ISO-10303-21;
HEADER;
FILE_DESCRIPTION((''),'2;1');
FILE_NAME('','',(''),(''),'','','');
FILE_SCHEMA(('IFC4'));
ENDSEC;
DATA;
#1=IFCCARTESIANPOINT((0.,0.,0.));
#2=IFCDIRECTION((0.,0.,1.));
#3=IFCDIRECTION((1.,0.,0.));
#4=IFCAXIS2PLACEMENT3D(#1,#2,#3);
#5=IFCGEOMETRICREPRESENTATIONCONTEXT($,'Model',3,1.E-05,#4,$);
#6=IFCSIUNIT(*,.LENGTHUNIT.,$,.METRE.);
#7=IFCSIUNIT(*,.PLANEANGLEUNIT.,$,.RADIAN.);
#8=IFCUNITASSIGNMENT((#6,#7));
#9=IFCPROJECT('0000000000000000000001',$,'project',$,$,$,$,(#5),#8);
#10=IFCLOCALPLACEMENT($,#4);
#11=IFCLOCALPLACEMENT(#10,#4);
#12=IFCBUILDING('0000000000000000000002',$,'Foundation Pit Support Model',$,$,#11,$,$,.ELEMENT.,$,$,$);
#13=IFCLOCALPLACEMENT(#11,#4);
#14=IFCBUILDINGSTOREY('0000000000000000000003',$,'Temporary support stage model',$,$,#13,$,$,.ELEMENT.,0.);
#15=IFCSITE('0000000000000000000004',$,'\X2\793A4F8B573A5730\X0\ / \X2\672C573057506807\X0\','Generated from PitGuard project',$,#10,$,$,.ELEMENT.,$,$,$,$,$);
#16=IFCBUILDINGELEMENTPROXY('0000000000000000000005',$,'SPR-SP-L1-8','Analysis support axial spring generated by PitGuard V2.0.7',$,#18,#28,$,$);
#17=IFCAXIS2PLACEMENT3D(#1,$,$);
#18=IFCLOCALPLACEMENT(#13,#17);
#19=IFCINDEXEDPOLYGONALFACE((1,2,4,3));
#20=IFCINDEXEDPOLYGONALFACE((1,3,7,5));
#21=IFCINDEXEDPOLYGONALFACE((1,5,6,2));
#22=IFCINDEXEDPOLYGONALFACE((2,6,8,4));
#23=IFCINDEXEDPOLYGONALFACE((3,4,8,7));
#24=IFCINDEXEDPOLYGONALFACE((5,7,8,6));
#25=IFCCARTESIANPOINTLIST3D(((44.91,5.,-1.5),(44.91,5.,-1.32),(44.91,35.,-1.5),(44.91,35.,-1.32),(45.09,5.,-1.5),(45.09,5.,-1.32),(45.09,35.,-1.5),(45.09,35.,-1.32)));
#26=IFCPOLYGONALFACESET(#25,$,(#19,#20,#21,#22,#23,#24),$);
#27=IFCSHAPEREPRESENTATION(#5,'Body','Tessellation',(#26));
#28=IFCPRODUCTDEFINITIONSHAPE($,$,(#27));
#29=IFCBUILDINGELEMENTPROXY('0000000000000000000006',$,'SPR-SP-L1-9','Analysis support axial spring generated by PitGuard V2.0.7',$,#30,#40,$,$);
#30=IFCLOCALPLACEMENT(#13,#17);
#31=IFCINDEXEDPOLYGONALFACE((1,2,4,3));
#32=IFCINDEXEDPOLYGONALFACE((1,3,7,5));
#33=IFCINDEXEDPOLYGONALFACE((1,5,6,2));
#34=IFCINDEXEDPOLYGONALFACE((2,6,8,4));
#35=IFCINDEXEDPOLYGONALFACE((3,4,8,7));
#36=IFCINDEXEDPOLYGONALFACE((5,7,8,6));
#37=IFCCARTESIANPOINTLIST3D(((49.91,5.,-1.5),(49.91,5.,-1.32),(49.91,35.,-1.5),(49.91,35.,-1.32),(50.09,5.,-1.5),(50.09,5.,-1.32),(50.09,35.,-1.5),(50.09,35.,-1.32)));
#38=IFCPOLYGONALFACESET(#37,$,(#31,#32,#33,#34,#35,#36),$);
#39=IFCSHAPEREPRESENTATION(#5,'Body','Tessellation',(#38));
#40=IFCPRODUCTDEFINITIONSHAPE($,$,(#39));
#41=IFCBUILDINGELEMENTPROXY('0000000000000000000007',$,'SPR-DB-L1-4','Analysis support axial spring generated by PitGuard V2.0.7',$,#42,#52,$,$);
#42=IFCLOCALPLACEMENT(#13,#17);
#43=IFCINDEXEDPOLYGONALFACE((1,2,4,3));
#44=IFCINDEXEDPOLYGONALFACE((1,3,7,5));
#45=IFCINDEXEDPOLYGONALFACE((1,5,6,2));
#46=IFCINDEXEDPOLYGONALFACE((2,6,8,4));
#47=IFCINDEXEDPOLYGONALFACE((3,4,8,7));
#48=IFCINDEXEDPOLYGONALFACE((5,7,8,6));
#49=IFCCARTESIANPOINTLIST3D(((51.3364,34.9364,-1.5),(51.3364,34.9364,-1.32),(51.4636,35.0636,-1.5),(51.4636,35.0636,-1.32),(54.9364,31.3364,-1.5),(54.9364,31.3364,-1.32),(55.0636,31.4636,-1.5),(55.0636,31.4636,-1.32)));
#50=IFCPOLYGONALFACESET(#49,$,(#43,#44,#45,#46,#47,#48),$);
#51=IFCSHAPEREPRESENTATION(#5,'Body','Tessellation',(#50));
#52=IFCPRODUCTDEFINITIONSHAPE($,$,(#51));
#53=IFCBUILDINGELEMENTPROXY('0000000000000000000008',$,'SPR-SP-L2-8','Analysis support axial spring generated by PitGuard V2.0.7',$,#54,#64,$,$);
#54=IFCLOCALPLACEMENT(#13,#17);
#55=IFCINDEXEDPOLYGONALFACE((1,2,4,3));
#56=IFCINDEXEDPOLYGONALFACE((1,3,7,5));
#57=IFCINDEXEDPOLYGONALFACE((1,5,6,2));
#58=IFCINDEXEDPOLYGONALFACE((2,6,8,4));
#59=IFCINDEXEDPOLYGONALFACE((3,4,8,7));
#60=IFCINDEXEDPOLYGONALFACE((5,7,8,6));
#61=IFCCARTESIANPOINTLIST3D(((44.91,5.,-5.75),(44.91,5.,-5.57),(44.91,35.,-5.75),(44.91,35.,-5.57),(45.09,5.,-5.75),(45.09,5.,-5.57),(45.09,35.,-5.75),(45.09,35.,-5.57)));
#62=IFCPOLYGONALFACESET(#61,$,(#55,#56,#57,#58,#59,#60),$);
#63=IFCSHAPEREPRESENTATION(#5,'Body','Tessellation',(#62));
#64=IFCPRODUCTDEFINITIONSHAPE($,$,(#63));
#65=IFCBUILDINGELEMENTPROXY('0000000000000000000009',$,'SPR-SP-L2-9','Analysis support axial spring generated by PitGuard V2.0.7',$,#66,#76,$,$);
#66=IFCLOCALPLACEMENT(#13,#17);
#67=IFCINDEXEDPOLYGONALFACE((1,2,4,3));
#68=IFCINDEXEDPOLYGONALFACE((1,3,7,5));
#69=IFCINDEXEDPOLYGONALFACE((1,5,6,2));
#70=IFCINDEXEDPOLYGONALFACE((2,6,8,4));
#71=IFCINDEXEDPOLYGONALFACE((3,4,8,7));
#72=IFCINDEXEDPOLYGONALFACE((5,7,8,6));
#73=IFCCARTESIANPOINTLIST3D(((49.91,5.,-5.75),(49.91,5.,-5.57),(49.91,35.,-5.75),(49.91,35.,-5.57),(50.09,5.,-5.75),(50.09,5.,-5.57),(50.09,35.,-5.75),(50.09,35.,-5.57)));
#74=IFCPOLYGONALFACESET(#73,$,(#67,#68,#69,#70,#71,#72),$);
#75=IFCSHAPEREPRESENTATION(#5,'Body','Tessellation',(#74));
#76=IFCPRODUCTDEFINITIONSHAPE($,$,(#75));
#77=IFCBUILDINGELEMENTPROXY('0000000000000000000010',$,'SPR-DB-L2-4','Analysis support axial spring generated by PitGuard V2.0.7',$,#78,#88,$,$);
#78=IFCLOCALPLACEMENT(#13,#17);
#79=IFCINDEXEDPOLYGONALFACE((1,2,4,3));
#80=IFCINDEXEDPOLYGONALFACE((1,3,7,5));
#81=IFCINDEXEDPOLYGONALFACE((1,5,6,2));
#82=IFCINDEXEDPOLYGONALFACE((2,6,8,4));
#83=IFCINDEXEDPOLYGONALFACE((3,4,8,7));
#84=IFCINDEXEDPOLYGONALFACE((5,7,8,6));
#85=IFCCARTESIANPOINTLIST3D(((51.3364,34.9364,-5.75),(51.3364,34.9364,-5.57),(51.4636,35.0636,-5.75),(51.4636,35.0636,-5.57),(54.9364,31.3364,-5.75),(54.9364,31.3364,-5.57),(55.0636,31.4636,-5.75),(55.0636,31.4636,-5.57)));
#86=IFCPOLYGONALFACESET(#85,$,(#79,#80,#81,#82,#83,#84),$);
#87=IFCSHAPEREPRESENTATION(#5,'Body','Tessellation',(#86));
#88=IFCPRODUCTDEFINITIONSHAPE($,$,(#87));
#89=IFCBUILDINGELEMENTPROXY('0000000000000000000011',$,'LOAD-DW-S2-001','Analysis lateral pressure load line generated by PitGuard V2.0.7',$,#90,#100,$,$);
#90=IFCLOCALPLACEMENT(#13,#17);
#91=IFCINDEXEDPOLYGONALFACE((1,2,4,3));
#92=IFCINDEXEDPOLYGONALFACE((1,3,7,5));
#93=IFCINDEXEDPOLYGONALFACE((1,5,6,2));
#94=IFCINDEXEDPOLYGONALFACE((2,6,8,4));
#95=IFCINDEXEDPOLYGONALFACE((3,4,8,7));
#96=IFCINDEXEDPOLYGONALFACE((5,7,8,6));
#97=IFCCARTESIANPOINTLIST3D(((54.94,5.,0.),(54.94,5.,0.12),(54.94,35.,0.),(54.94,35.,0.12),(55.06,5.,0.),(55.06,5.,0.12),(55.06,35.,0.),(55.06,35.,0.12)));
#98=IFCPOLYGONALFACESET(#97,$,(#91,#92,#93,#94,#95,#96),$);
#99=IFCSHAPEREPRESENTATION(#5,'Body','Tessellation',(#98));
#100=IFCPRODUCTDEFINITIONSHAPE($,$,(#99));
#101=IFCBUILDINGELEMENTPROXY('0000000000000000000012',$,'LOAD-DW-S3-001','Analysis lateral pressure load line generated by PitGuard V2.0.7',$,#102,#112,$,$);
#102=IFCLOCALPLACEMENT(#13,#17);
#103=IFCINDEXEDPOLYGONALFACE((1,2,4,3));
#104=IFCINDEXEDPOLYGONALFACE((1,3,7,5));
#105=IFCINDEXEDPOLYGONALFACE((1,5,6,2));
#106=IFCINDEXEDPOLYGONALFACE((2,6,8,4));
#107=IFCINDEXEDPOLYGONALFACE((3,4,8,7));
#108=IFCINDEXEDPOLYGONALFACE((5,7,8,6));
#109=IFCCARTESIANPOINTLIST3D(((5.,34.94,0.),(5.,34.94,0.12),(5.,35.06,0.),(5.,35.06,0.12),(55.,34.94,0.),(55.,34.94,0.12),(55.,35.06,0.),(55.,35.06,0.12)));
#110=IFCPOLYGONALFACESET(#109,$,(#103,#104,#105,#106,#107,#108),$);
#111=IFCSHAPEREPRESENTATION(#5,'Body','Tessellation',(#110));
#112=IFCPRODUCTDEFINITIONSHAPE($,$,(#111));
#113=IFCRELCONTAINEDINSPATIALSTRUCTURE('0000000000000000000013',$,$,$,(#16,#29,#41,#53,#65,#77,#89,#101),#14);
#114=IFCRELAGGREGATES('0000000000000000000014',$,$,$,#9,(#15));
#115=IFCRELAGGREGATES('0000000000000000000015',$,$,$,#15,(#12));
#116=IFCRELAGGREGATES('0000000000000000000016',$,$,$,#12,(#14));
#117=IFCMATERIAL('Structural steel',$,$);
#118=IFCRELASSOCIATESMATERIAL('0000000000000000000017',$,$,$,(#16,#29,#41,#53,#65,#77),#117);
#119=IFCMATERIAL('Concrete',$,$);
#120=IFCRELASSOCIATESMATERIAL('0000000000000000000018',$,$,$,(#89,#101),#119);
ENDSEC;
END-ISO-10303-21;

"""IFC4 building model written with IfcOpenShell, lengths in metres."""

from ifc_helpers import new_model, si_unit, frame, origin_with_axes, origin_2d, place, context, project, spatial, rectangle, extrude, material, element, save


model = new_model("IFC4")

# Units and contexts
model_context = context("Model", 3, precision=1e-05, world=origin_with_axes())
ifc_project = project(units=[si_unit("LENGTHUNIT", "METRE"), si_unit("PLANEANGLEUNIT", "RADIAN")], contexts=[model_context])

# Site, building, storey
site_placement = place(None, origin_with_axes())
site = spatial("IfcSite", under=ifc_project, at=site_placement, Name="示例场地 / 本地坐标", Description="Generated from PitGuard project", CompositionType="ELEMENT")
building_placement = place(site_placement, origin_with_axes())
building = spatial("IfcBuilding", under=site, at=building_placement, Name="Foundation Pit Support Model", CompositionType="ELEMENT")
storey_placement = place(building_placement, origin_with_axes())
storey = spatial("IfcBuildingStorey", under=building, at=storey_placement, Name="Temporary support stage model", CompositionType="ELEMENT", Elevation=0.0)

# Shared definitions
ifc_material_1 = material(Name="Concrete")

# Building element proxies
ifc_material_2 = material(Name="Structural steel")
for number, where, z_axis, x_axis, name in (
    (1, (45.0, 20.0, -1.5), (0.0, 0.0, 1.0), (0.0, 1.0, 0.0), "SPR-SP-L1-8"),
    (2, (50.0, 20.0, -1.5), (0.0, 0.0, 1.0), (0.0, 1.0, 0.0), "SPR-SP-L1-9"),
):
    element("IfcBuildingElementProxy", number, at=place(storey_placement, frame(where, z_axis=z_axis, x_axis=x_axis)), inside=storey, material=ifc_material_2, Name=name, Description="Analysis support axial spring generated by PitGuard V2.0.7", context=model_context, shape_type="SweptSolid", body=[
        extrude(rectangle(XDim=30.0, YDim=0.18, at=origin_2d()), origin_with_axes(), (0.0, 0.0, 1.0), 0.18),
    ])
proxy_1_placement = place(storey_placement, frame((53.2, 33.2, -1.5), z_axis=(0.0, 0.0, 1.0), x_axis=(-0.707107, 0.707107, 0.0)))
element("IfcBuildingElementProxy", 3, at=proxy_1_placement, inside=storey, material=ifc_material_2, Name="SPR-DB-L1-4", Description="Analysis support axial spring generated by PitGuard V2.0.7", context=model_context, shape_type="SweptSolid", body=[
    extrude(rectangle(XDim=5.0912, YDim=0.18, at=origin_2d()), origin_with_axes(), (0.0, 0.0, 1.0), 0.18),
])
for number, where, z_axis, x_axis, name in (
    (4, (45.0, 20.0, -5.75), (0.0, 0.0, 1.0), (0.0, 1.0, 0.0), "SPR-SP-L2-8"),
    (5, (50.0, 20.0, -5.75), (0.0, 0.0, 1.0), (0.0, 1.0, 0.0), "SPR-SP-L2-9"),
):
    element("IfcBuildingElementProxy", number, at=place(storey_placement, frame(where, z_axis=z_axis, x_axis=x_axis)), inside=storey, material=ifc_material_2, Name=name, Description="Analysis support axial spring generated by PitGuard V2.0.7", context=model_context, shape_type="SweptSolid", body=[
        extrude(rectangle(XDim=30.0, YDim=0.18, at=origin_2d()), origin_with_axes(), (0.0, 0.0, 1.0), 0.18),
    ])
proxy_2_placement = place(storey_placement, frame((53.2, 33.2, -5.75), z_axis=(0.0, 0.0, 1.0), x_axis=(-0.707107, 0.707107, 0.0)))
element("IfcBuildingElementProxy", 6, at=proxy_2_placement, inside=storey, material=ifc_material_2, Name="SPR-DB-L2-4", Description="Analysis support axial spring generated by PitGuard V2.0.7", context=model_context, shape_type="SweptSolid", body=[
    extrude(rectangle(XDim=5.0912, YDim=0.18, at=origin_2d()), origin_with_axes(), (0.0, 0.0, 1.0), 0.18),
])
proxy_3_placement = place(storey_placement, frame((55.0, 20.0, 0.0), z_axis=(0.0, 0.0, 1.0), x_axis=(0.0, 1.0, 0.0)))
element("IfcBuildingElementProxy", 7, at=proxy_3_placement, inside=storey, material=ifc_material_1, Name="LOAD-DW-S2-001", Description="Analysis lateral pressure load line generated by PitGuard V2.0.7", context=model_context, shape_type="SweptSolid", body=[
    extrude(rectangle(XDim=30.0, YDim=0.12, at=origin_2d()), origin_with_axes(), (0.0, 0.0, 1.0), 0.12),
])
proxy_4_placement = place(storey_placement, frame((30.0, 35.0, 0.0), z_axis=(0.0, 0.0, 1.0), x_axis=(-1.0, 0.0, 0.0)))
element("IfcBuildingElementProxy", 8, at=proxy_4_placement, inside=storey, material=ifc_material_1, Name="LOAD-DW-S3-001", Description="Analysis lateral pressure load line generated by PitGuard V2.0.7", context=model_context, shape_type="SweptSolid", body=[
    extrude(rectangle(XDim=50.0, YDim=0.12, at=origin_2d()), origin_with_axes(), (0.0, 0.0, 1.0), 0.12),
])

save(model, "model.ifc")
